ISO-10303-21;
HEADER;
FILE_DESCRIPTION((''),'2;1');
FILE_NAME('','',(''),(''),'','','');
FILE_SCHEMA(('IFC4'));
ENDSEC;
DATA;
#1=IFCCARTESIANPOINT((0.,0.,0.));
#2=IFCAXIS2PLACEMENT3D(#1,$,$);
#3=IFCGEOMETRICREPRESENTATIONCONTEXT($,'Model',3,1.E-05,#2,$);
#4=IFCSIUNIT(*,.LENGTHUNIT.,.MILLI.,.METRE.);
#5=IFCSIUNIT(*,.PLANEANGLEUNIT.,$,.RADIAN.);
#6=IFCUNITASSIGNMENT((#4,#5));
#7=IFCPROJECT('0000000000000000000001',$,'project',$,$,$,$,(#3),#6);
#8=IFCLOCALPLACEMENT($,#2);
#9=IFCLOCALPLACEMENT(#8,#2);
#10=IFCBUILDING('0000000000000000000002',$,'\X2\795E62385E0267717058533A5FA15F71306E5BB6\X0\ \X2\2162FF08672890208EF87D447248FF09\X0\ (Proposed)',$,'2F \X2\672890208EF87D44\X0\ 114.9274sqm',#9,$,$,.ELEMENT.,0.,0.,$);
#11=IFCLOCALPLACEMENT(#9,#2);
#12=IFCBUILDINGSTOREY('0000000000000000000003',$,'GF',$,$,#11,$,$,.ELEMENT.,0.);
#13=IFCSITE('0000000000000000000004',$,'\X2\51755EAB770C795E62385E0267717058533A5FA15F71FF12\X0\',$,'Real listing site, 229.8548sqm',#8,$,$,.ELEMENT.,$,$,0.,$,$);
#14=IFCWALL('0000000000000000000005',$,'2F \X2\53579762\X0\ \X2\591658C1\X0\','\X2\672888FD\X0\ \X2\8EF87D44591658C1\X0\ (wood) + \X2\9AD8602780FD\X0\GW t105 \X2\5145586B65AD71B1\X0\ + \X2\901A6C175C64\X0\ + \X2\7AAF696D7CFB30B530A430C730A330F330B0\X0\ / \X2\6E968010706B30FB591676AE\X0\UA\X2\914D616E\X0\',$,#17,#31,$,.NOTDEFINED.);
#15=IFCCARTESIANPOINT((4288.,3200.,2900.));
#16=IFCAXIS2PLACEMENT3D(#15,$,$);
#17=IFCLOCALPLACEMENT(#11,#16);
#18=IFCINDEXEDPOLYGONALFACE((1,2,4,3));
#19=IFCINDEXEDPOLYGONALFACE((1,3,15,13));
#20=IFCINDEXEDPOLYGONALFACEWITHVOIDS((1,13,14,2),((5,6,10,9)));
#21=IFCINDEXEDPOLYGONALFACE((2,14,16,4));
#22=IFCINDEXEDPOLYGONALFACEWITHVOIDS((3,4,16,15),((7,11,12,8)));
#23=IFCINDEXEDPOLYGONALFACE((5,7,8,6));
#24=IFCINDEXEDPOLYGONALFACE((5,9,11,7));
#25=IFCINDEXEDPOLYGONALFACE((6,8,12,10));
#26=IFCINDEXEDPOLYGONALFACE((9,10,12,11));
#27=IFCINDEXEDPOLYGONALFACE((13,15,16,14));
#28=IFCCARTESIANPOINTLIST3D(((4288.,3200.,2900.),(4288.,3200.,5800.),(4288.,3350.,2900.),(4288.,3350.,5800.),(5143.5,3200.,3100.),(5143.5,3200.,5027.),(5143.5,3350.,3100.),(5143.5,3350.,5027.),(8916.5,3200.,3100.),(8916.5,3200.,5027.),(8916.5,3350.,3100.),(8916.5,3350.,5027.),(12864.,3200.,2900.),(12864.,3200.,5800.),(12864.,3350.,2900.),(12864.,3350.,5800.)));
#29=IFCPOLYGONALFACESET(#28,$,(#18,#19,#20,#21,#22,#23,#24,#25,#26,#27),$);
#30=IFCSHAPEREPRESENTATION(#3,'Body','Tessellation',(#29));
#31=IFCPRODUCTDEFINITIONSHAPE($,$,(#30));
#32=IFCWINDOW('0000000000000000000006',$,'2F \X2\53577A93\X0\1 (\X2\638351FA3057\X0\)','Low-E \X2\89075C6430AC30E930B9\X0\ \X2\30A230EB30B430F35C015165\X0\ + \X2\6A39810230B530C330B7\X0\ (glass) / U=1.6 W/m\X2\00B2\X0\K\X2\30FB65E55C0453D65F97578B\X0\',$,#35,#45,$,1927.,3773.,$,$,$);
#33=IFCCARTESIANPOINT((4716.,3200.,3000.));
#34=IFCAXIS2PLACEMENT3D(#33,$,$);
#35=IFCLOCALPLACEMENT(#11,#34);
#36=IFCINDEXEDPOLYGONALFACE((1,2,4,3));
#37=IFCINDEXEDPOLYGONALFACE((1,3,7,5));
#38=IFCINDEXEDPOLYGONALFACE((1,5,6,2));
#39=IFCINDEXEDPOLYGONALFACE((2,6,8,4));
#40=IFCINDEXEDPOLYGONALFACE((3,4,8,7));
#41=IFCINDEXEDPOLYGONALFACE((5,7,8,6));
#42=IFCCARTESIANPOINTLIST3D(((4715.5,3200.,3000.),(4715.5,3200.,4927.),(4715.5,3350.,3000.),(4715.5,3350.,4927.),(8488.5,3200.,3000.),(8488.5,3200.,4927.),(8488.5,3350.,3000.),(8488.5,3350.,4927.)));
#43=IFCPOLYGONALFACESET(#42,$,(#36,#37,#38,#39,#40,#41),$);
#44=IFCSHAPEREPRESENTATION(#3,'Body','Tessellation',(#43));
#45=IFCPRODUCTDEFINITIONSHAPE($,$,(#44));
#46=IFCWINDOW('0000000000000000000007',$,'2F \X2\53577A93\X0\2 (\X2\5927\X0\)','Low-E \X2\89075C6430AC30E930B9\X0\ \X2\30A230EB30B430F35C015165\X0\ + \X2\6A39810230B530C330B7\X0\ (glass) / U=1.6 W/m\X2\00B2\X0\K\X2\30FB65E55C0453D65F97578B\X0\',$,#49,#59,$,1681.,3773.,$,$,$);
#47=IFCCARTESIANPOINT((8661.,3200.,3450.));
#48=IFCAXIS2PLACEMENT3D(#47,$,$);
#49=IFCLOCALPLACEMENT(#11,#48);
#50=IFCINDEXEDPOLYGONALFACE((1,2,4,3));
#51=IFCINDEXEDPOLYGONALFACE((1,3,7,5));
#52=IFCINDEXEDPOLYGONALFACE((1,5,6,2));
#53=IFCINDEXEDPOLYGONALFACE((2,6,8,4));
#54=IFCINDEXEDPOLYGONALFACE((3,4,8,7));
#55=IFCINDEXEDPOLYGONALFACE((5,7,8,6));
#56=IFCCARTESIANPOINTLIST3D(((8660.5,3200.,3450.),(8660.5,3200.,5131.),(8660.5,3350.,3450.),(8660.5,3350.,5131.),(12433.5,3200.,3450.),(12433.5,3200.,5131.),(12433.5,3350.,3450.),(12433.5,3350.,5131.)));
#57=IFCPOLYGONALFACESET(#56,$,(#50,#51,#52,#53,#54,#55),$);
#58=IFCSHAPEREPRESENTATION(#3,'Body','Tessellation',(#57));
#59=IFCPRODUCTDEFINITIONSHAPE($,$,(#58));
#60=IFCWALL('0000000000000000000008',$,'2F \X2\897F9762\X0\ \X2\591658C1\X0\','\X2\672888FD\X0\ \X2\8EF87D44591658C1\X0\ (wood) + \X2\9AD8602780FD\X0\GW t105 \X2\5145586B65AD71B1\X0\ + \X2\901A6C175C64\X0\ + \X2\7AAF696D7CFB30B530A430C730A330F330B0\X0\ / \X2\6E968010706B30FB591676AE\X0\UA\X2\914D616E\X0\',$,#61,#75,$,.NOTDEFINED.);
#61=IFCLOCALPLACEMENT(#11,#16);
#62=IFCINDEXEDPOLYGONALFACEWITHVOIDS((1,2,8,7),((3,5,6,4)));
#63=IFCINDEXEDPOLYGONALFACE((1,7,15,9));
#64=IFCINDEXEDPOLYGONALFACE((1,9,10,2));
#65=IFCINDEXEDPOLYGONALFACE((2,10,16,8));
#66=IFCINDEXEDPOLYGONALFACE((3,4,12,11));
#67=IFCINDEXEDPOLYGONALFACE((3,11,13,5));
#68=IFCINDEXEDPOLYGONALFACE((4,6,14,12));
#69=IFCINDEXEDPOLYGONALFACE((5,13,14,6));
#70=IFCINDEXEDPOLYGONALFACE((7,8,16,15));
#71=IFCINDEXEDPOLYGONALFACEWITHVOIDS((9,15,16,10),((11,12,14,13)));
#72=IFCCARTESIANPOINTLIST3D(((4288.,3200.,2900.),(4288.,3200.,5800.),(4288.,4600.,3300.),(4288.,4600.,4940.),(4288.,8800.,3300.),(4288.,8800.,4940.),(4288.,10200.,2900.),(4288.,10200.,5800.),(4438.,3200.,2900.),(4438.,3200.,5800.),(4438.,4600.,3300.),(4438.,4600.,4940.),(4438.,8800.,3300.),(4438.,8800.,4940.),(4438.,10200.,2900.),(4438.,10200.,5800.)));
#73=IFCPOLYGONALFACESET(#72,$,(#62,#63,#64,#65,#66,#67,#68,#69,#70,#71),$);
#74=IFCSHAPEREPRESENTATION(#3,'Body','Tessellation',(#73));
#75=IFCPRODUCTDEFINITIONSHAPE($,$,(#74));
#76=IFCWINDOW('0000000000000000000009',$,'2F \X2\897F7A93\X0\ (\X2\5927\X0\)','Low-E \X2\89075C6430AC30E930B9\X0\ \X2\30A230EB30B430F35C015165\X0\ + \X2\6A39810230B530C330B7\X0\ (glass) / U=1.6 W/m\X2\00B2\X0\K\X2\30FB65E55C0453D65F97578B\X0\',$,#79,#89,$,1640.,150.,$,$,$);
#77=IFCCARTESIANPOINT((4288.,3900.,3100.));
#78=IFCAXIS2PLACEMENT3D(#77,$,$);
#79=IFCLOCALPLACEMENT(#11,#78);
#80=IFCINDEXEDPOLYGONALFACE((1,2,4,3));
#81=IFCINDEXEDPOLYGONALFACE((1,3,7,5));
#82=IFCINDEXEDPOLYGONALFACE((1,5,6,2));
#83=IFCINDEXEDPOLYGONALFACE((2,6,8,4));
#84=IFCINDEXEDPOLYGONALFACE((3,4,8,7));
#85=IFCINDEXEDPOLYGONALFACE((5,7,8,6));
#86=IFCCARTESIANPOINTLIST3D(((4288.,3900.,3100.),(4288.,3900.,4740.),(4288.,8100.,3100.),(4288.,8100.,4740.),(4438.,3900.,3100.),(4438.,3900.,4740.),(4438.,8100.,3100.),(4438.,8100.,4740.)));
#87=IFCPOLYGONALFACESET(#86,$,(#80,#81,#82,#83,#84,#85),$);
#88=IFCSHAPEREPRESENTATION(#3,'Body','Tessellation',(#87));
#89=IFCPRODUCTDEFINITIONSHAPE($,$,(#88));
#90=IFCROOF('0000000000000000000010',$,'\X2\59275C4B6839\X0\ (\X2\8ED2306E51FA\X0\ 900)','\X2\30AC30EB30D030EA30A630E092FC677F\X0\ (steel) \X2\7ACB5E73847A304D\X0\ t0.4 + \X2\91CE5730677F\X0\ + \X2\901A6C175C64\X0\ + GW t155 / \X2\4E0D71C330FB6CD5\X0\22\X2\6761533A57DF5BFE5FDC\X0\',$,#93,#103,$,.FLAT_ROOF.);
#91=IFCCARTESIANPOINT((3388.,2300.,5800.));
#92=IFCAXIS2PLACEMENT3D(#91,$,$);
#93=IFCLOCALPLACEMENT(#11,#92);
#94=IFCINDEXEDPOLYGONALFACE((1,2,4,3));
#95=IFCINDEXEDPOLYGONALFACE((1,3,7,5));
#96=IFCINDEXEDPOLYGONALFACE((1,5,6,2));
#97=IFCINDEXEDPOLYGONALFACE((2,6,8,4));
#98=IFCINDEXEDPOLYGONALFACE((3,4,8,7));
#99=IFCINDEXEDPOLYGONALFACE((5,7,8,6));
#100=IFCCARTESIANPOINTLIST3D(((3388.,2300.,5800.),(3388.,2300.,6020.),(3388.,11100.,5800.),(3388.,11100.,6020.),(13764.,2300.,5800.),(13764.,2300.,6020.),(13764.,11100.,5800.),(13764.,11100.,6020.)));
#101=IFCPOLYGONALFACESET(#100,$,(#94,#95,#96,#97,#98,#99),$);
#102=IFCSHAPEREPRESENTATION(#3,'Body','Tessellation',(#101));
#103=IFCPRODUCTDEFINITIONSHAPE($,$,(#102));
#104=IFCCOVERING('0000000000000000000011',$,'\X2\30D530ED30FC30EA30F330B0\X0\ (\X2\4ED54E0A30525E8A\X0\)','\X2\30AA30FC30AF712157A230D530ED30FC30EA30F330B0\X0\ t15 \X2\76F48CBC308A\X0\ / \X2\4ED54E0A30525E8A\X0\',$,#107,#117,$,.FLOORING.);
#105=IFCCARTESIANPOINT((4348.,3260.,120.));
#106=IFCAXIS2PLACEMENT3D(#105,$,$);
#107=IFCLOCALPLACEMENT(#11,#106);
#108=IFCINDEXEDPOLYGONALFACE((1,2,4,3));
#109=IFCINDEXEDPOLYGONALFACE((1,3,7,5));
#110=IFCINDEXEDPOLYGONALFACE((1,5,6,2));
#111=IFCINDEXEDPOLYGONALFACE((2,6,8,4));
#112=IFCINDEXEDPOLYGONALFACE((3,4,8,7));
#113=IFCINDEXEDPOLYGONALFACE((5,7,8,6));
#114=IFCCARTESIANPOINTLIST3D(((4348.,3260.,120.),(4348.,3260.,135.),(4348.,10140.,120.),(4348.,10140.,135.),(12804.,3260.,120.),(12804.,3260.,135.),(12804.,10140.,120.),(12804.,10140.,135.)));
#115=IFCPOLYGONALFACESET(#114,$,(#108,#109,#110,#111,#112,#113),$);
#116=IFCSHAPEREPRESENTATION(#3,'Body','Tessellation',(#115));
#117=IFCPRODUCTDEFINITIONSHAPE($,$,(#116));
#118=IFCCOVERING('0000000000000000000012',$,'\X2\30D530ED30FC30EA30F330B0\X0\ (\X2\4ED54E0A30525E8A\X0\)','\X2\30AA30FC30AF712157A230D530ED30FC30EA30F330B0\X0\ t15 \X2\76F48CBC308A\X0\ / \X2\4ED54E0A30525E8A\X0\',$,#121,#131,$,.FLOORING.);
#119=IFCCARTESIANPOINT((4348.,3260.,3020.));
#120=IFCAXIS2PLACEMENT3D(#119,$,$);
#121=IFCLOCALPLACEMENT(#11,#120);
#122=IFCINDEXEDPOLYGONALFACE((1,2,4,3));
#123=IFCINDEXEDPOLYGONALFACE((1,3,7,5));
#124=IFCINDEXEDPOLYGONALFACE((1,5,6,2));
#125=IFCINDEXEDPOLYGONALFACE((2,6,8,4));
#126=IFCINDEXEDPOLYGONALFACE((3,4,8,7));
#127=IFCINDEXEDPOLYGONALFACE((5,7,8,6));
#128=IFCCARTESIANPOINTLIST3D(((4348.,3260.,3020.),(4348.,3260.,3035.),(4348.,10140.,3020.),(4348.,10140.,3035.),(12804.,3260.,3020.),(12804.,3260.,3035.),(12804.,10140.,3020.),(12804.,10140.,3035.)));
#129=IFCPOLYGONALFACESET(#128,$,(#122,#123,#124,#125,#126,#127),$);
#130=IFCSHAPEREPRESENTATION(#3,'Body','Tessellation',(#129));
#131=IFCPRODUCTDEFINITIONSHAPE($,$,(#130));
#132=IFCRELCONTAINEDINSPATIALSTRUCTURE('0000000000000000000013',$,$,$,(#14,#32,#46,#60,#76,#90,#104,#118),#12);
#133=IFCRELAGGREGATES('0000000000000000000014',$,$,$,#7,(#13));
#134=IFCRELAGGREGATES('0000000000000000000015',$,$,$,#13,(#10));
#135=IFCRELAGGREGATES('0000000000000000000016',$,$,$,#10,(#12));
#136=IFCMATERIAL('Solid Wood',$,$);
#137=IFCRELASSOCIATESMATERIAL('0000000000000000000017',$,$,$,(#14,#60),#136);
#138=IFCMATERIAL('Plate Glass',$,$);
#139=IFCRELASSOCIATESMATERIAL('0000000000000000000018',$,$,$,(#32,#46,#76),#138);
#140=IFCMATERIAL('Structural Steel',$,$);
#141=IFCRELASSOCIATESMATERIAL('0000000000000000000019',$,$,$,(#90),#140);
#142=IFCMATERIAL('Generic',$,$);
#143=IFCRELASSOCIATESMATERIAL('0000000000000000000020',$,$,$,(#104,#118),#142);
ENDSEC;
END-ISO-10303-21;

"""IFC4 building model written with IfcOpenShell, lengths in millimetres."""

from ifc_helpers import new_model, si_unit, frame, frame_2d, origin, place, context, project, spatial, rectangle, extrude, material, element, fill, save


model = new_model("IFC4")

# Units and contexts
model_context = context("Model", 3, precision=1e-05, world=origin())
ifc_project = project(units=[si_unit("LENGTHUNIT", "METRE", prefix="MILLI"), si_unit("PLANEANGLEUNIT", "RADIAN")], contexts=[model_context])

# Site, building, storey
site_placement = place(None, origin())
site = spatial("IfcSite", under=ifc_project, at=site_placement, Name="兵庫県神戸市東灘区御影２", ObjectType="Real listing site, 229.8548sqm", CompositionType="ELEMENT", RefElevation=0.0)
building_placement = place(site_placement, origin())
building = spatial("IfcBuilding", under=site, at=building_placement, Name="神戸市東灘区御影の家 Ⅲ（木造軸組版） (Proposed)", ObjectType="2F 木造軸組 114.9274sqm", CompositionType="ELEMENT", ElevationOfRefHeight=0.0, ElevationOfTerrain=0.0)
storey_placement = place(building_placement, origin())
storey = spatial("IfcBuildingStorey", under=building, at=storey_placement, Name="GF", CompositionType="ELEMENT", Elevation=0.0)

# Shared definitions
ifc_material_1 = material(Name="Solid Wood")

# Shared definitions
ifc_material_2 = material(Name="Plate Glass")

# Wall, openings, windows
wall_1_placement = place(storey_placement, frame((4288.0, 3200.0, 2900.0)))
wall_1 = element("IfcWall", 1, at=wall_1_placement, inside=storey, material=ifc_material_1, Name="2F 南面 外壁", Description="木製 軸組外壁 (wood) + 高性能GW t105 充填断熱 + 通気層 + 窯業系サイディング / 準耐火・外皮UA配慮", PredefinedType="NOTDEFINED", context=model_context, shape_type="SweptSolid", body=[
    extrude(rectangle(XDim=8576.0, YDim=150.0, at=frame_2d((4288.0, 75.0))), frame((4288.0, 3200.0, 2900.0)), (0.0, 0.0, 1.0), 2900.0),
])
opening_1_placement = place(storey_placement, frame((4716.0, 3200.0, 3000.0)))
opening_1 = element("IfcOpeningElement", 2, at=opening_1_placement, cuts=wall_1, PredefinedType="NOTDEFINED", context=model_context, shape_type="SweptSolid", body=[
    extrude(rectangle(XDim=3773.0, YDim=150.0, at=frame_2d((1886.0, 75.0))), frame((4716.0, 3200.0, 3000.0)), (0.0, 0.0, 1.0), 1927.0),
])
opening_2_placement = place(storey_placement, frame((8661.0, 3200.0, 3450.0)))
opening_2 = element("IfcOpeningElement", 3, at=opening_2_placement, cuts=wall_1, PredefinedType="NOTDEFINED", context=model_context, shape_type="SweptSolid", body=[
    extrude(rectangle(XDim=3773.0, YDim=150.0, at=frame_2d((1886.0, 75.0))), frame((8661.0, 3200.0, 3450.0)), (0.0, 0.0, 1.0), 1681.0),
])
window_1_placement = place(storey_placement, frame((4716.0, 3200.0, 3000.0)))
window_1 = element("IfcWindow", 4, at=window_1_placement, inside=storey, material=ifc_material_2, Name="2F 南窓1 (掃出し)", Description="Low-E 複層ガラス アルゴン封入 + 樹脂サッシ (glass) / U=1.6 W/m²K・日射取得型", OverallHeight=1927.0, OverallWidth=3773.0, context=model_context, shape_type="SweptSolid", body=[
    extrude(rectangle(XDim=3773.0, YDim=150.0, at=frame_2d((1886.0, 75.0))), frame((4716.0, 3200.0, 3000.0)), (0.0, 0.0, 1.0), 1927.0),
])
fill(opening_1, window_1)
window_2_placement = place(storey_placement, frame((8661.0, 3200.0, 3450.0)))
window_2 = element("IfcWindow", 5, at=window_2_placement, inside=storey, material=ifc_material_2, Name="2F 南窓2 (大)", Description="Low-E 複層ガラス アルゴン封入 + 樹脂サッシ (glass) / U=1.6 W/m²K・日射取得型", OverallHeight=1681.0, OverallWidth=3773.0, context=model_context, shape_type="SweptSolid", body=[
    extrude(rectangle(XDim=3773.0, YDim=150.0, at=frame_2d((1886.0, 75.0))), frame((8661.0, 3200.0, 3450.0)), (0.0, 0.0, 1.0), 1681.0),
])
fill(opening_2, window_2)

# Wall, opening, window
wall_2_placement = place(storey_placement, frame((4288.0, 3200.0, 2900.0)))
wall_2 = element("IfcWall", 6, at=wall_2_placement, inside=storey, material=ifc_material_1, Name="2F 西面 外壁", Description="木製 軸組外壁 (wood) + 高性能GW t105 充填断熱 + 通気層 + 窯業系サイディング / 準耐火・外皮UA配慮", PredefinedType="NOTDEFINED", context=model_context, shape_type="SweptSolid", body=[
    extrude(rectangle(XDim=150.0, YDim=7000.0, at=frame_2d((75.0, 3500.0))), frame((4288.0, 3200.0, 2900.0)), (0.0, 0.0, 1.0), 2900.0),
])
opening_3_placement = place(storey_placement, frame((4288.0, 3900.0, 3100.0)))
opening_3 = element("IfcOpeningElement", 7, at=opening_3_placement, cuts=wall_2, PredefinedType="NOTDEFINED", context=model_context, shape_type="SweptSolid", body=[
    extrude(rectangle(XDim=150.0, YDim=4200.0, at=frame_2d((75.0, 2100.0))), frame((4288.0, 3900.0, 3100.0)), (0.0, 0.0, 1.0), 1640.0),
])
window_3_placement = place(storey_placement, frame((4288.0, 3900.0, 3100.0)))
window_3 = element("IfcWindow", 8, at=window_3_placement, inside=storey, material=ifc_material_2, Name="2F 西窓 (大)", Description="Low-E 複層ガラス アルゴン封入 + 樹脂サッシ (glass) / U=1.6 W/m²K・日射取得型", OverallHeight=1640.0, OverallWidth=150.0, context=model_context, shape_type="SweptSolid", body=[
    extrude(rectangle(XDim=150.0, YDim=4200.0, at=frame_2d((75.0, 2100.0))), frame((4288.0, 3900.0, 3100.0)), (0.0, 0.0, 1.0), 1640.0),
])
fill(opening_3, window_3)

# Roof
ifc_material_3 = material(Name="Structural Steel")
roof_placement = place(storey_placement, frame((3388.0, 2300.0, 5800.0)))
element("IfcRoof", 9, at=roof_placement, inside=storey, material=ifc_material_3, Name="大屋根 (軒の出 900)", Description="ガルバリウム鋼板 (steel) 立平葺き t0.4 + 野地板 + 通気層 + GW t155 / 不燃・法22条区域対応", PredefinedType="FLAT_ROOF", context=model_context, shape_type="SweptSolid", body=[
    extrude(rectangle(XDim=10376.0, YDim=8800.0, at=frame_2d((5188.0, 4400.0))), frame((3388.0, 2300.0, 5800.0)), (0.0, 0.0, 1.0), 220.0),
])

# Coverings
ifc_material_4 = material(Name="Generic")
covering_1_placement = place(storey_placement, frame((4348.0, 3260.0, 120.0)))
element("IfcCovering", 10, at=covering_1_placement, inside=storey, material=ifc_material_4, Name="フローリング (仕上げ床)", Description="オーク無垢フローリング t15 直貼り / 仕上げ床", PredefinedType="FLOORING", context=model_context, shape_type="SweptSolid", body=[
    extrude(rectangle(XDim=8456.0, YDim=6880.0, at=frame_2d((4228.0, 3440.0))), frame((4348.0, 3260.0, 120.0)), (0.0, 0.0, 1.0), 15.0),
])
covering_2_placement = place(storey_placement, frame((4348.0, 3260.0, 3020.0)))
element("IfcCovering", 11, at=covering_2_placement, inside=storey, material=ifc_material_4, Name="フローリング (仕上げ床)", Description="オーク無垢フローリング t15 直貼り / 仕上げ床", PredefinedType="FLOORING", context=model_context, shape_type="SweptSolid", body=[
    extrude(rectangle(XDim=8456.0, YDim=6880.0, at=frame_2d((4228.0, 3440.0))), frame((4348.0, 3260.0, 3020.0)), (0.0, 0.0, 1.0), 15.0),
])

save(model, "model.ifc")
